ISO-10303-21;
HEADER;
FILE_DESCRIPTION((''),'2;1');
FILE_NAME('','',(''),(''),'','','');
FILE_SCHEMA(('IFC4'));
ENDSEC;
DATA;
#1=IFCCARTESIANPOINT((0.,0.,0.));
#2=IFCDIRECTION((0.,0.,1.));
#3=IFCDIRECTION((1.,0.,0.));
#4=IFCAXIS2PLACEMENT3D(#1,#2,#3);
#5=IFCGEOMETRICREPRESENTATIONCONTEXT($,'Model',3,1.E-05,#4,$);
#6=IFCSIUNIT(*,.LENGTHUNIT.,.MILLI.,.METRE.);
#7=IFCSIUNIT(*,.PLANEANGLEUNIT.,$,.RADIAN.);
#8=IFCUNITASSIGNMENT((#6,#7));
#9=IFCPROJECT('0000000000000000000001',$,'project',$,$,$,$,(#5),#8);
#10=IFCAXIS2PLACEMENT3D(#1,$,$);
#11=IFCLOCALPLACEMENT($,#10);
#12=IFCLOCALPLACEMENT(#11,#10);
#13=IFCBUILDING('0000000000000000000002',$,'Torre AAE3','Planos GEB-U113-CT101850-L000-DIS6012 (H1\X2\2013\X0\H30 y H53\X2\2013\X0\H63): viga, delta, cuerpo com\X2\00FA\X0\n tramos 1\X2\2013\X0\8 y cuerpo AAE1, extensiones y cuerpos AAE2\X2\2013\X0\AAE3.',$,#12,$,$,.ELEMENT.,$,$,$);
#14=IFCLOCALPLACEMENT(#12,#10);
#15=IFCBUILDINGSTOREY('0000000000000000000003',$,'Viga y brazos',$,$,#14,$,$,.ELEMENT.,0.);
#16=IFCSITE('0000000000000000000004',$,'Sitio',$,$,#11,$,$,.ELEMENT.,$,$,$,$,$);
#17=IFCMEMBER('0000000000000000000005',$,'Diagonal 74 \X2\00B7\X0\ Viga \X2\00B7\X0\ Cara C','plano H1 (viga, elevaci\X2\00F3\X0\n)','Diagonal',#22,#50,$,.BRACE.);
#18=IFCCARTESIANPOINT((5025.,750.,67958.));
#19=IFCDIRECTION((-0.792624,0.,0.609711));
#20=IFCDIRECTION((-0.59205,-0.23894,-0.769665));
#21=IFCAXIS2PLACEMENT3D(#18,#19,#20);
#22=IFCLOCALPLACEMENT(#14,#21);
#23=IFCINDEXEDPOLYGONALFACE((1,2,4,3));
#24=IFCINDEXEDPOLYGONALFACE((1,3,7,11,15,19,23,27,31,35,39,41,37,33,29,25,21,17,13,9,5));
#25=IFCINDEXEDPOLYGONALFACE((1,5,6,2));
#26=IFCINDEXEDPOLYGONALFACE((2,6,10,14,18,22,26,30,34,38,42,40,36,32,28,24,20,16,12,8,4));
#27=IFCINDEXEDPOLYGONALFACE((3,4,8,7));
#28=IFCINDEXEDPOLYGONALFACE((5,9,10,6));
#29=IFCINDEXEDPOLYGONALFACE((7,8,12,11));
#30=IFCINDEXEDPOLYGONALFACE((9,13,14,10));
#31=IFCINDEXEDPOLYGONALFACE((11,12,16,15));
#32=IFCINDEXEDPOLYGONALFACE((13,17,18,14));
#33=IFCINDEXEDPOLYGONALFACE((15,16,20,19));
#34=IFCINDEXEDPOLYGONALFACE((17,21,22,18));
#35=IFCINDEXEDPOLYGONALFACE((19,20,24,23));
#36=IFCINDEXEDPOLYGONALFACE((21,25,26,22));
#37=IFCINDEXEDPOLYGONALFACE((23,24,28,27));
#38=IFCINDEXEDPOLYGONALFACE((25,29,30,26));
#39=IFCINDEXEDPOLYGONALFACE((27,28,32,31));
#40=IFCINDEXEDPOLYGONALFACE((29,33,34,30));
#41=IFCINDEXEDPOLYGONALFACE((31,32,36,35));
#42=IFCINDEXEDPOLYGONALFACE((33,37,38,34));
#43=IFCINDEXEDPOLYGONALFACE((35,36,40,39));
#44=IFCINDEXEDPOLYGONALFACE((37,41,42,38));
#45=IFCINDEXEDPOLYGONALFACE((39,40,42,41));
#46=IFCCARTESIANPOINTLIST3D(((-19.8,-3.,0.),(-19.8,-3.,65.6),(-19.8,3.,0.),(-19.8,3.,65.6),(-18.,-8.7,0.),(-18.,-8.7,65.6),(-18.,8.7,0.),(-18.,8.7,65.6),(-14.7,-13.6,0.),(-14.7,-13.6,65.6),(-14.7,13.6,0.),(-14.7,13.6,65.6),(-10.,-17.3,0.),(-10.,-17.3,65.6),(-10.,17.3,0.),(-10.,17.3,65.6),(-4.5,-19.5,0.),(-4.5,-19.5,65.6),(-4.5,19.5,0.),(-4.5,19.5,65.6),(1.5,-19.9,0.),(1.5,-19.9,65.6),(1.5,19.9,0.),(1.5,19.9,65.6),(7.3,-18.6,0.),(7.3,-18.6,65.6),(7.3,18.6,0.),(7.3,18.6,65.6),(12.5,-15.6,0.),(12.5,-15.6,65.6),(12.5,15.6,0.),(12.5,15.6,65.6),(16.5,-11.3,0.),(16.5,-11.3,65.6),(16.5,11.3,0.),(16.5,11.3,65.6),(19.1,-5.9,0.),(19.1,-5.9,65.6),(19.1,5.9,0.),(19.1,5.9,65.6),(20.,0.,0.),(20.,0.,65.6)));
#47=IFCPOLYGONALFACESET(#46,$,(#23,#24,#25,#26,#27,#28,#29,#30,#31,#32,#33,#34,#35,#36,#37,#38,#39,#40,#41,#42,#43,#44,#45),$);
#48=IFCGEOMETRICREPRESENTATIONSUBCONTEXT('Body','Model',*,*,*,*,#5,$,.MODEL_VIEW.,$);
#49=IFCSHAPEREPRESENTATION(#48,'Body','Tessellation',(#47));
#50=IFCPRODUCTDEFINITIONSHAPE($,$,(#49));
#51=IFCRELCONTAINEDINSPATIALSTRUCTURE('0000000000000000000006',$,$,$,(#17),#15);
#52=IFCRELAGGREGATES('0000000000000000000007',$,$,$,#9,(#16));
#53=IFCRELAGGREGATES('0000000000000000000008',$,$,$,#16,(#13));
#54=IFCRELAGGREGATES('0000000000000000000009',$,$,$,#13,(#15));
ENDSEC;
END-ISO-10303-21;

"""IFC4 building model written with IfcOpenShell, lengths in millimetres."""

from ifc_helpers import new_model, si_unit, frame, origin, origin_with_axes, place, context, subcontext, project, spatial, circle, extrude, element, save


model = new_model("IFC4")

# Units and contexts
model_context = context("Model", 3, precision=1e-05, world=origin_with_axes())
body_context = subcontext(model_context, "Body", "Model", "MODEL_VIEW")
ifc_project = project(units=[si_unit("LENGTHUNIT", "METRE", prefix="MILLI"), si_unit("PLANEANGLEUNIT", "RADIAN")], contexts=[model_context])

# Site, building, storey
site_placement = place(None, origin())
site = spatial("IfcSite", under=ifc_project, at=site_placement, Name="Sitio", CompositionType="ELEMENT")
building_placement = place(site_placement, origin())
building = spatial("IfcBuilding", under=site, at=building_placement, Name="Torre AAE3", Description="Planos GEB-U113-CT101850-L000-DIS6012 (H1–H30 y H53–H63): viga, delta, cuerpo común tramos 1–8 y cuerpo AAE1, extensiones y cuerpos AAE2–AAE3.", CompositionType="ELEMENT")
storey_placement = place(building_placement, origin())
storey = spatial("IfcBuildingStorey", under=building, at=storey_placement, Name="Viga y brazos", CompositionType="ELEMENT", Elevation=0.0)

# Member
member_1_placement = place(storey_placement, frame((5025.0, 750.0, 67958.0), z_axis=(-0.792624, 0.0, 0.609711), x_axis=(-0.59205, -0.23894, -0.769665)))
element("IfcMember", 1, at=member_1_placement, inside=storey, Name="Diagonal 74 · Viga · Cara C", Description="plano H1 (viga, elevación)", ObjectType="Diagonal", PredefinedType="BRACE", context=body_context, shape_type="SweptSolid", body=[
    extrude(circle(Radius=20.0), None, (0.0, 0.0, 1.0), 65.6),
])

save(model, "model.ifc")
